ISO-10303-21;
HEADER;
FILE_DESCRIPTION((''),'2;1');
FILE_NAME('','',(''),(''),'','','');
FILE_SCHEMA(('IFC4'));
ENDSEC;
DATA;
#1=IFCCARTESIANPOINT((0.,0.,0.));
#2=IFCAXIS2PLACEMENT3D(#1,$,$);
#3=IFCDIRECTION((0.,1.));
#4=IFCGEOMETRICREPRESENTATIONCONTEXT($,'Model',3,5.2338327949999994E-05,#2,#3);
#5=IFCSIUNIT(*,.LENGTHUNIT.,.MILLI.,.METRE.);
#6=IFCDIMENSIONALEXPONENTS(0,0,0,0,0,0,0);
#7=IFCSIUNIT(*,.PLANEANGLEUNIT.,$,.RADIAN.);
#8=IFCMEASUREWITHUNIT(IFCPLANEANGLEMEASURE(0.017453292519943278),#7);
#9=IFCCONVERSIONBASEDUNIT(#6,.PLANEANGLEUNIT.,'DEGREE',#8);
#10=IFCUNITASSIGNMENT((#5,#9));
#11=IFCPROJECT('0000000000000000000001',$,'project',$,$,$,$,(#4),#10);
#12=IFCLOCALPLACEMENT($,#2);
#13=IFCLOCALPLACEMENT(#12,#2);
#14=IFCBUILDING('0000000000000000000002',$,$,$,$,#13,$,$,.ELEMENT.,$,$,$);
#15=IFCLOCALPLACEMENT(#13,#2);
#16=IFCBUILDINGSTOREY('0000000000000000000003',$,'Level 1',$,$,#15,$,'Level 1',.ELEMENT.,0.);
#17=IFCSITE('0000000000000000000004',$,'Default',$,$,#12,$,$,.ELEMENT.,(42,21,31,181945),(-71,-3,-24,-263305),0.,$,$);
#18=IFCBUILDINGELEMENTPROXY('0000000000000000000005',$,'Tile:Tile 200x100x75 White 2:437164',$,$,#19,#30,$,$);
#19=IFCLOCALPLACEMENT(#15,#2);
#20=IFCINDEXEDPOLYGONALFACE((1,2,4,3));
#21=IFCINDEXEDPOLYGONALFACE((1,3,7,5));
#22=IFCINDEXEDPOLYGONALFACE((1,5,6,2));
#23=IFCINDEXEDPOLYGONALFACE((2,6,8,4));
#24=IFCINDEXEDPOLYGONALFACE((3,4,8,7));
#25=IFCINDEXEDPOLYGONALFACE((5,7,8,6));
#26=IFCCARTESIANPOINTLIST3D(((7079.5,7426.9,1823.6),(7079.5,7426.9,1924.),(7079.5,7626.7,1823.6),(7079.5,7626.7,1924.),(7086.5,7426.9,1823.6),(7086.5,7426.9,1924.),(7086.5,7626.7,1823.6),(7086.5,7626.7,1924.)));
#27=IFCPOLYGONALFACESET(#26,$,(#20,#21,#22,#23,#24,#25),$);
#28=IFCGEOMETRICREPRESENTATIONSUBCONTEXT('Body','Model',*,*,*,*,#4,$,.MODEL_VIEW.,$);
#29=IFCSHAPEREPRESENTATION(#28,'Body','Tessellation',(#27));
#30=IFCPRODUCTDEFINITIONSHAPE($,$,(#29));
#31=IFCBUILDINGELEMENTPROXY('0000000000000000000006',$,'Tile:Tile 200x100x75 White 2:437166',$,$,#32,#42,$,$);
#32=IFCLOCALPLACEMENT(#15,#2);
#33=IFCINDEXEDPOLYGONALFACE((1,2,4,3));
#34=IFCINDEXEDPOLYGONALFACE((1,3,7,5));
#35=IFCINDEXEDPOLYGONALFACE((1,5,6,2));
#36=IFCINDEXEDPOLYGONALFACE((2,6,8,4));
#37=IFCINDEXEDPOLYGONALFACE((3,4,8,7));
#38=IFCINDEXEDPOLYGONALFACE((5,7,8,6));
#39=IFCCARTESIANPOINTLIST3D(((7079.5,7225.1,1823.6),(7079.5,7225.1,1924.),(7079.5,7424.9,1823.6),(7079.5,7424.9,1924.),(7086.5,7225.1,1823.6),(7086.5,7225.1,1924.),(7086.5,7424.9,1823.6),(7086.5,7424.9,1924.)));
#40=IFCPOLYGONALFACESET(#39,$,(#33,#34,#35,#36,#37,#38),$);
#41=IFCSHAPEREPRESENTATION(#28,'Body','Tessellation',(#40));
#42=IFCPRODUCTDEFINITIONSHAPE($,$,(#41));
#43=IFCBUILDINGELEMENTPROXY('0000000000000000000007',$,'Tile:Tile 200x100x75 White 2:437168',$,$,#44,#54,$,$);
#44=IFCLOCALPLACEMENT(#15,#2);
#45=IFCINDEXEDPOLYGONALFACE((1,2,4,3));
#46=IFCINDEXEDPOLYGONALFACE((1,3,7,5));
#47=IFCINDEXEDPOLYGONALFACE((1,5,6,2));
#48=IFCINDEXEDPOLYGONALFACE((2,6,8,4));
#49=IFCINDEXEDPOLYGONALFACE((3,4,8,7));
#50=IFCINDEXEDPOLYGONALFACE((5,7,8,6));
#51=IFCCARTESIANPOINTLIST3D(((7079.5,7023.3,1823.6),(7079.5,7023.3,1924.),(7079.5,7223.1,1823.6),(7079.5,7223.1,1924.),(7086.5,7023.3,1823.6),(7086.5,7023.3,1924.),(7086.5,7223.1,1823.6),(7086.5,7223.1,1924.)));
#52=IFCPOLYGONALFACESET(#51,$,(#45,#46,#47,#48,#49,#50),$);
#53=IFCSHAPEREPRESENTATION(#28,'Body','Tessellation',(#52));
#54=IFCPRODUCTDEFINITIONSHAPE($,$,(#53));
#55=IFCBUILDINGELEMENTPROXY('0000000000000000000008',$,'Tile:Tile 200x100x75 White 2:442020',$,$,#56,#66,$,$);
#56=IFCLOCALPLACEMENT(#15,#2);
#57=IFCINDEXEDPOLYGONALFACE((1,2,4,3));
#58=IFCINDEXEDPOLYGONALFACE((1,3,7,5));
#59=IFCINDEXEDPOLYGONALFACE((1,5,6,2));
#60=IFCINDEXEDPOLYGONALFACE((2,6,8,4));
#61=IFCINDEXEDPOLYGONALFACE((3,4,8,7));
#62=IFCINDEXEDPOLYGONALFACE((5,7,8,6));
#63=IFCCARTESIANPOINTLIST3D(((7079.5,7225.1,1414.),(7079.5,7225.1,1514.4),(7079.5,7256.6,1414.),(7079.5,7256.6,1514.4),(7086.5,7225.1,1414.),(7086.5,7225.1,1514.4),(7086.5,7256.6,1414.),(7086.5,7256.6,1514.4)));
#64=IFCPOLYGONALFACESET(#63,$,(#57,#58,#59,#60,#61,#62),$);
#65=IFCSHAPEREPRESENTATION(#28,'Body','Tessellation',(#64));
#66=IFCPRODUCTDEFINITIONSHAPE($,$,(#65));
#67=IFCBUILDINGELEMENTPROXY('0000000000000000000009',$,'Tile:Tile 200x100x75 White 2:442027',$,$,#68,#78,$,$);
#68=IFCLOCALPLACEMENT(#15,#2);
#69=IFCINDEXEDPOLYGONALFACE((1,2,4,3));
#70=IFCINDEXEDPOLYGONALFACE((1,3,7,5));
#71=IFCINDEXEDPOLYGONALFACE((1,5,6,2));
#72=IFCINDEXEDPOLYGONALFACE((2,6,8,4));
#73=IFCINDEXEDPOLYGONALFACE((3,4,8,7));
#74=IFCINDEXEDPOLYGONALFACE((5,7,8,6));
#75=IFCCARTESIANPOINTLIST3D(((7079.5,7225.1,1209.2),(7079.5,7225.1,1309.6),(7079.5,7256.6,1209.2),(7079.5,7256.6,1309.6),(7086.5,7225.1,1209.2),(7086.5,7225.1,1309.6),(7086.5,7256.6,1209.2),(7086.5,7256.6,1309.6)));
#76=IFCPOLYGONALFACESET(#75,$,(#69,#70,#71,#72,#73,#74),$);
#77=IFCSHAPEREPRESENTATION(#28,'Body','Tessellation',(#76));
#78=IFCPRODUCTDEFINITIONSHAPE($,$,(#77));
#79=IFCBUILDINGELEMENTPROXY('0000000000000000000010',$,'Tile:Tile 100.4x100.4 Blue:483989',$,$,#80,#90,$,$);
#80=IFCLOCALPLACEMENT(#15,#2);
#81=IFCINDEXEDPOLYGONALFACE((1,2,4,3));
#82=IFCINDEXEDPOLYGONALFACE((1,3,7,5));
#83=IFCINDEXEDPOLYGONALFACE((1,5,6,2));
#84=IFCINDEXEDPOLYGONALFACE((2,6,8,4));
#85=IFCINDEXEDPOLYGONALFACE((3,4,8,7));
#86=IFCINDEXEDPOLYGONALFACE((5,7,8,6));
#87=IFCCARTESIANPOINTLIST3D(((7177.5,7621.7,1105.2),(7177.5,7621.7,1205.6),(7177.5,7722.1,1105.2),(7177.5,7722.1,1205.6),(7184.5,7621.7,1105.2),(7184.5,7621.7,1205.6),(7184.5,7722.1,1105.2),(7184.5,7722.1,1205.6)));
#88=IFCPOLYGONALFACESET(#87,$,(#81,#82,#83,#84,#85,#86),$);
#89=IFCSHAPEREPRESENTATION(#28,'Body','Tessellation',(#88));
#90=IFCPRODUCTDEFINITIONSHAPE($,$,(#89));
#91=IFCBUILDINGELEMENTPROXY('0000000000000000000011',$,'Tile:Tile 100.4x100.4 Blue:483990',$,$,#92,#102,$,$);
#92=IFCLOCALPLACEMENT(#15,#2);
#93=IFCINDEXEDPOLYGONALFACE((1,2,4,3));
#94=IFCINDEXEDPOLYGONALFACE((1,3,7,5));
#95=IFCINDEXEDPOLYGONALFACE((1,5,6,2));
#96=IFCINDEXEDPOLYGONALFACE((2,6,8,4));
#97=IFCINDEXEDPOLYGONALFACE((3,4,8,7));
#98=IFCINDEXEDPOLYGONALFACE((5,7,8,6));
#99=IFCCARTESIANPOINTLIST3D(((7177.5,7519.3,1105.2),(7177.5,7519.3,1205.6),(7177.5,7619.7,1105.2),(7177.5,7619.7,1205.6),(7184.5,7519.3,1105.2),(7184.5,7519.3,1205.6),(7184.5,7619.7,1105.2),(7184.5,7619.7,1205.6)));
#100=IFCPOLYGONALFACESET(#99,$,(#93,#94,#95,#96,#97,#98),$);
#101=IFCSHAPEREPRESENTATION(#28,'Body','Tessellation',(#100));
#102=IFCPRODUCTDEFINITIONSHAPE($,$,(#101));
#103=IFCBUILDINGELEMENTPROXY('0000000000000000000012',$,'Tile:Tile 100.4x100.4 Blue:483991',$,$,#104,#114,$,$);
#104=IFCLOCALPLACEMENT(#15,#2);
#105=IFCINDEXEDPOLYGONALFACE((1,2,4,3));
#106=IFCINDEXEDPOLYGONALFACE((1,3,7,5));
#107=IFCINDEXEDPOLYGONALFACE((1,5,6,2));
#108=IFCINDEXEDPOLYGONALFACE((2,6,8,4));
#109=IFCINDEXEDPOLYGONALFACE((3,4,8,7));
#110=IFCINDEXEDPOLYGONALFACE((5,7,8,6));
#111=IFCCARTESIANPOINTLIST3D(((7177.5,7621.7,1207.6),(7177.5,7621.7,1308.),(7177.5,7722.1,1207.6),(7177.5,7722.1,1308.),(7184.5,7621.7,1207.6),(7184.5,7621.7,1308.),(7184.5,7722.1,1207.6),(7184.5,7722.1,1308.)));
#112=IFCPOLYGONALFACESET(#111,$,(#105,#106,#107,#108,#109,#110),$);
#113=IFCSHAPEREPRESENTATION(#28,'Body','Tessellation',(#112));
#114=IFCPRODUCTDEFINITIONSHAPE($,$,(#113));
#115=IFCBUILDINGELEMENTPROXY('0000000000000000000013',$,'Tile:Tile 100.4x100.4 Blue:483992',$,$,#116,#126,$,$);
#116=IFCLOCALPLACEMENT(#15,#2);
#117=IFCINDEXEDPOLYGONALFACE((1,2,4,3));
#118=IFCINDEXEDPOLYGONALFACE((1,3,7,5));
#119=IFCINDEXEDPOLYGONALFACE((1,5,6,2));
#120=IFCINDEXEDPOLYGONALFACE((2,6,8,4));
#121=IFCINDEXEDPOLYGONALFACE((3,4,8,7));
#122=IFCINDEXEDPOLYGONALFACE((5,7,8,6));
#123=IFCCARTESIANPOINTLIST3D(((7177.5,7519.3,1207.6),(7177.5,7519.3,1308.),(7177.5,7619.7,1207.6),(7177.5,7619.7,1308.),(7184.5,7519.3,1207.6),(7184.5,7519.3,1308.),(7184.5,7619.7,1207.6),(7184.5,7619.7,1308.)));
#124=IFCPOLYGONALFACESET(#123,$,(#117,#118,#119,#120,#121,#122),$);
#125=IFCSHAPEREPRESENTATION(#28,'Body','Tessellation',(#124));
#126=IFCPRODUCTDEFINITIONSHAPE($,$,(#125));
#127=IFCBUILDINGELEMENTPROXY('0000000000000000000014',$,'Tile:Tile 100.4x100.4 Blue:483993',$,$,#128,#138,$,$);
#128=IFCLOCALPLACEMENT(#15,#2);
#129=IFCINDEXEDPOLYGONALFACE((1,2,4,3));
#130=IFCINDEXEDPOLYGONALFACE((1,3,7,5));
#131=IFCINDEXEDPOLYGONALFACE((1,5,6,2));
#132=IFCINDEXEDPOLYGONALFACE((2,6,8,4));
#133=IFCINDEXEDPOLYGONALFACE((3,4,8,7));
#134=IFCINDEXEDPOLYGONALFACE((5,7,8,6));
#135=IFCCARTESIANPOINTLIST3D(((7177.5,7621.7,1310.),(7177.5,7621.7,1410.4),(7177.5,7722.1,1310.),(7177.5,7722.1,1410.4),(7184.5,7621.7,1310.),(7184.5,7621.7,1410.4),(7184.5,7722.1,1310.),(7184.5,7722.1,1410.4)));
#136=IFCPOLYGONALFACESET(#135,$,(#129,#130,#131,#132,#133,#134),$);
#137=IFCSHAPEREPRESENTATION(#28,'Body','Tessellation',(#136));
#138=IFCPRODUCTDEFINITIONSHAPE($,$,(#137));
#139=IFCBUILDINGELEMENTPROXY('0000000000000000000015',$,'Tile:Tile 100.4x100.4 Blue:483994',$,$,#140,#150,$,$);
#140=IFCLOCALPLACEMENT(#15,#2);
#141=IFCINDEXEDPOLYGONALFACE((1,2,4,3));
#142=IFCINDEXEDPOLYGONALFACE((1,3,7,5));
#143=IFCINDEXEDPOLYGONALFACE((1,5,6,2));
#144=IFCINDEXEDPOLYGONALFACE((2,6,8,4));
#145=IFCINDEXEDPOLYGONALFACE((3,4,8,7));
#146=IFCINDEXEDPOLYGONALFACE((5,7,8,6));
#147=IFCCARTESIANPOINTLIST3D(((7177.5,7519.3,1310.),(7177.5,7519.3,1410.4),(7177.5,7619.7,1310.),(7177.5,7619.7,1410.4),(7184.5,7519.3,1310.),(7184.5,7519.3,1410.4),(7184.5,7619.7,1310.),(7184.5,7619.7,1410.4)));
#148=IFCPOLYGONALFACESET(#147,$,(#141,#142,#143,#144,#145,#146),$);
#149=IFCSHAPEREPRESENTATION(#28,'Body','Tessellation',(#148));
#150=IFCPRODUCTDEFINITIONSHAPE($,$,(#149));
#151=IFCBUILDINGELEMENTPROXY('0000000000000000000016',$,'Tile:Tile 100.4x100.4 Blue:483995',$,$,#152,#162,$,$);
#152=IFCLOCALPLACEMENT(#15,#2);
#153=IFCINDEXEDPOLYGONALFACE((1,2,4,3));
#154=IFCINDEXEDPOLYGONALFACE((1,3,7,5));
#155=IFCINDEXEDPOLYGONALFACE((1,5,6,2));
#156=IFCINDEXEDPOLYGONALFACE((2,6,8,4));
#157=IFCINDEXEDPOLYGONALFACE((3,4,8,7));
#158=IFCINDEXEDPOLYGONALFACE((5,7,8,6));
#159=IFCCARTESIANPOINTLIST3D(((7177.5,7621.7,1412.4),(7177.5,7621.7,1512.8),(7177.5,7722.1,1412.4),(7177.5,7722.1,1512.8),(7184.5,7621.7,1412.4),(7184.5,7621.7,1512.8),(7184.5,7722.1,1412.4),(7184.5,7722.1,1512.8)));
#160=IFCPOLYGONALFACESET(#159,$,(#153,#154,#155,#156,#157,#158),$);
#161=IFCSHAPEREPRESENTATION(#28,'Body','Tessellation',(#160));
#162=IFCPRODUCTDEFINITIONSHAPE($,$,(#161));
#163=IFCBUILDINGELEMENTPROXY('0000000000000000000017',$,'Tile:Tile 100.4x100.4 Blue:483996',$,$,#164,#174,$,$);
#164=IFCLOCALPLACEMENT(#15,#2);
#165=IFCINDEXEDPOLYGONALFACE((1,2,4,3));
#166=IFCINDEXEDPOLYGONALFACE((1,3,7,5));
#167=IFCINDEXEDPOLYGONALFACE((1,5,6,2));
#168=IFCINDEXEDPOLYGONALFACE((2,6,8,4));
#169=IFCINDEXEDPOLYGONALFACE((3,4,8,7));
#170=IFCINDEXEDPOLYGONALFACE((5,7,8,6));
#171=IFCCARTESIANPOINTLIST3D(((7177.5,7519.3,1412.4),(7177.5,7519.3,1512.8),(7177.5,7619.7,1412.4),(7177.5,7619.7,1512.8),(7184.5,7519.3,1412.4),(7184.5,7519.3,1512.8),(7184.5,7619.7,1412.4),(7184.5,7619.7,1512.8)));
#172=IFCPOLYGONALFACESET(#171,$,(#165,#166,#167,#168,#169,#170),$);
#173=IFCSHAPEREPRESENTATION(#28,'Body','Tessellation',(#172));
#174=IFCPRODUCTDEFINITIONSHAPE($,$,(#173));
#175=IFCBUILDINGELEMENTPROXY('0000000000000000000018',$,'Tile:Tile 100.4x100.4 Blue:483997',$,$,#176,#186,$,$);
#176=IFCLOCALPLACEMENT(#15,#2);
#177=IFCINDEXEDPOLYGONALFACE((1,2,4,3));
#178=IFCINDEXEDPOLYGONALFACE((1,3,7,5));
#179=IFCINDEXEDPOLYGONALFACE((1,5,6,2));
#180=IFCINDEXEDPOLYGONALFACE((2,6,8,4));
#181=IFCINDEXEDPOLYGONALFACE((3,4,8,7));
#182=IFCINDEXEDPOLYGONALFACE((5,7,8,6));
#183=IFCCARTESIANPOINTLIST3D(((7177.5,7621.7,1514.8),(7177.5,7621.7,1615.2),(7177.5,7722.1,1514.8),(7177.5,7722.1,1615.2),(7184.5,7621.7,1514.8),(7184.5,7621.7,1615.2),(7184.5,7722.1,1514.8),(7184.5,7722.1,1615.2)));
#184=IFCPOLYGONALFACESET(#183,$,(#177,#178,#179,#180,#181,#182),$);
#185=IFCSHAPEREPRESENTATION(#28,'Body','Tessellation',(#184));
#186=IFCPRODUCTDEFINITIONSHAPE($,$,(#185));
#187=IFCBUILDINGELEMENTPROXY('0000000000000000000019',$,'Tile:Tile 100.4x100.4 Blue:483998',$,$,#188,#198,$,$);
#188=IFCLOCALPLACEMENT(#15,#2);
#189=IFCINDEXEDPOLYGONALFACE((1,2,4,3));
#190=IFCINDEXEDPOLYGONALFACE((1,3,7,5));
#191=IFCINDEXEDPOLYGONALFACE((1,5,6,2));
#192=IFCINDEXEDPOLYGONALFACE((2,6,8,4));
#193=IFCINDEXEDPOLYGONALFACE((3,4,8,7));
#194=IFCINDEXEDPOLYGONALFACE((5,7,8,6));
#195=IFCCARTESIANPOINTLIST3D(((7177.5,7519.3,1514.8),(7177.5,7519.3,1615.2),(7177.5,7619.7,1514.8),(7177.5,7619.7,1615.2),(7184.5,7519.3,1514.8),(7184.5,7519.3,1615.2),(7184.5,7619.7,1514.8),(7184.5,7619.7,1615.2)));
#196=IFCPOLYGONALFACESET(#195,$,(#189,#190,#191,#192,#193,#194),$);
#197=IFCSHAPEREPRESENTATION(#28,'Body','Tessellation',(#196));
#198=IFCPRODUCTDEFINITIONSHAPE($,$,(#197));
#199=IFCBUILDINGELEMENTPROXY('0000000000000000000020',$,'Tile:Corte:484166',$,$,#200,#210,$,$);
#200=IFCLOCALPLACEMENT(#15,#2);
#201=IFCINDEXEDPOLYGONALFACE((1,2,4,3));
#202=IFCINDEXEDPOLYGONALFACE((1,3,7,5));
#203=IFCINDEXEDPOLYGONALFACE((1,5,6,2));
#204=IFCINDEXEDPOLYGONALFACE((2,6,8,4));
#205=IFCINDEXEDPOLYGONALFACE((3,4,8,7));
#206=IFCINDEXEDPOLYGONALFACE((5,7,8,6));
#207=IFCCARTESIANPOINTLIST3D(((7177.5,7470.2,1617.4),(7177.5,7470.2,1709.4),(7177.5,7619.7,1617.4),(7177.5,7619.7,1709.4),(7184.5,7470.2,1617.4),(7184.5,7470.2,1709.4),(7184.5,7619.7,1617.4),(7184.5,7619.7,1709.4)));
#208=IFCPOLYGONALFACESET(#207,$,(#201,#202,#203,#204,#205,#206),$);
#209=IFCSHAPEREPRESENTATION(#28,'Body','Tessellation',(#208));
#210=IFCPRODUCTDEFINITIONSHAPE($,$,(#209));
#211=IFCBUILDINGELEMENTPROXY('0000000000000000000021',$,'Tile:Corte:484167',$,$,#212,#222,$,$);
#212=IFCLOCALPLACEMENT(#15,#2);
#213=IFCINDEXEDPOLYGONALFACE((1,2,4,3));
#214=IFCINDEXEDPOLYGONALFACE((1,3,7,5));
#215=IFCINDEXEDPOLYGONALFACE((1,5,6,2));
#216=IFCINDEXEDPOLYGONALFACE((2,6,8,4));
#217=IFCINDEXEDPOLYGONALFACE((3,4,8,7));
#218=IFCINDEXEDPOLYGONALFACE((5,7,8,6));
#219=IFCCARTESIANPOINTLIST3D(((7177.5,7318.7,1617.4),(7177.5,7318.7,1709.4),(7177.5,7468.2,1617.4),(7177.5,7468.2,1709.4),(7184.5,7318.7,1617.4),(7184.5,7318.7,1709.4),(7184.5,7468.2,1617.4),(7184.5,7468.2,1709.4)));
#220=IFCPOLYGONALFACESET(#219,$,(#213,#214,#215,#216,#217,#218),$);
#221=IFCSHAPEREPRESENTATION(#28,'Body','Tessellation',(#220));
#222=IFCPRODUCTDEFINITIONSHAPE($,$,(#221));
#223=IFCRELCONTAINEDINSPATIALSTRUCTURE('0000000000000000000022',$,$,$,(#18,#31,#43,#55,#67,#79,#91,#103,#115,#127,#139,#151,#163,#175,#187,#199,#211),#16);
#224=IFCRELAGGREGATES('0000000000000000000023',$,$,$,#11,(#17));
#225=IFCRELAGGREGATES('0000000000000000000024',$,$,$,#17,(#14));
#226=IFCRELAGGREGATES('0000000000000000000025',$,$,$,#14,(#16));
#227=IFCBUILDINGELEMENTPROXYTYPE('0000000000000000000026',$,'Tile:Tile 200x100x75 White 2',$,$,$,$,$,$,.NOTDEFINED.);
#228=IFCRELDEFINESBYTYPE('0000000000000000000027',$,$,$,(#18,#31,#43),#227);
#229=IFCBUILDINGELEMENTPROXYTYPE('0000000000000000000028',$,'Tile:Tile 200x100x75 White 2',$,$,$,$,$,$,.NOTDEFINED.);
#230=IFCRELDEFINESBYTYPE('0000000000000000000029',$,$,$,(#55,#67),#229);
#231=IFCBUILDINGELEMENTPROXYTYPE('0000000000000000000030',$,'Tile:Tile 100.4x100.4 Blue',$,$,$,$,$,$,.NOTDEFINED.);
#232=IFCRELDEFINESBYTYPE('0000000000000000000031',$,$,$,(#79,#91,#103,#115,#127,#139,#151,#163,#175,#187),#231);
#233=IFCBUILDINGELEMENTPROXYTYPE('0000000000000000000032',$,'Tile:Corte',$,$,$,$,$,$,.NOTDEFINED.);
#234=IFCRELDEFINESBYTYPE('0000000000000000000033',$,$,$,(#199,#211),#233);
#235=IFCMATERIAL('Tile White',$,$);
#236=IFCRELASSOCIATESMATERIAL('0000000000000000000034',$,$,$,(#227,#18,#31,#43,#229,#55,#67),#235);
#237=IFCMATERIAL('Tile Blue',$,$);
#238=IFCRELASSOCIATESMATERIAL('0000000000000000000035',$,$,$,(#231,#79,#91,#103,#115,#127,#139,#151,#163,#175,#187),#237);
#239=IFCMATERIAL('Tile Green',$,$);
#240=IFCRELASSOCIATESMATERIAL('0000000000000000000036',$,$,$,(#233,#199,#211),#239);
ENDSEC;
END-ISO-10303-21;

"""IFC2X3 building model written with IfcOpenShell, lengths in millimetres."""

from ifc_helpers import new_model, entity, si_unit, converted_unit, direction, frame, frame_2d, origin, origin_2d_with_axis, place, context, subcontext, project, spatial, rectangle, extrude, source, transform, mapped, material, type_object, type_shapes, element, save


model = new_model("IFC2X3")

# Units and contexts
model_context = context("Model", 3, precision=5.2338327949999994e-05, world=origin(), true_north=direction((0.0, 1.0)))
body_context = subcontext(model_context, "Body", "Model", "MODEL_VIEW")
ifc_project = project(units=[si_unit("LENGTHUNIT", "METRE", prefix="MILLI"), converted_unit("PLANEANGLEUNIT", "DEGREE", entity("IfcPlaneAngleMeasure", 0.017453292519943278), si_unit("PLANEANGLEUNIT", "RADIAN"), dimensions=[0, 0, 0, 0, 0, 0, 0])], contexts=[model_context])

# Site, building, storey
site_placement = place(None, origin())
site = spatial("IfcSite", under=ifc_project, at=site_placement, Name="Default", CompositionType="ELEMENT", RefLatitude=(42, 21, 31, 181945), RefLongitude=(-71, -3, -24, -263305), RefElevation=0.0)
building_placement = place(site_placement, origin())
building = spatial("IfcBuilding", under=site, at=building_placement, CompositionType="ELEMENT")
storey_placement = place(building_placement, origin())
storey = spatial("IfcBuildingStorey", under=building, at=storey_placement, Name="Level 1", LongName="Level 1", CompositionType="ELEMENT", Elevation=0.0)

# Building element proxies
ifc_material_1 = material(Name="Tile White")
building_element_proxy_type_1 = type_object("IfcBuildingElementProxyType", Name="Tile:Tile 200x100x75 White 2", PredefinedType="NOTDEFINED", material=ifc_material_1)
shared_shape_1 = source(origin(), body_context, "Body", "SweptSolid", [
    extrude(rectangle(XDim=199.8, YDim=100.4, at=frame_2d((0.0, 0.0), x_axis=(1.0, 0.0))), frame((-50.2, -99.9, 0.0), z_axis=(0.0, 0.0, 1.0), x_axis=(0.0, -1.0, 0.0)), (0.0, 0.0, 1.0), 7.0),
])
type_shapes(building_element_proxy_type_1, [shared_shape_1])
for number, where, z_axis, x_axis, name in (
    (1, (7086.5, 7626.7, 1924.0), (-1.0, 0.0, 0.0), (0.0, 0.0, 1.0), "Tile:Tile 200x100x75 White 2:437164"),
    (2, (7086.5, 7424.9, 1924.0), (-1.0, 0.0, 0.0), (0.0, 0.0, 1.0), "Tile:Tile 200x100x75 White 2:437166"),
    (3, (7086.5, 7223.1, 1924.0), (-1.0, 0.0, 0.0), (0.0, 0.0, 1.0), "Tile:Tile 200x100x75 White 2:437168"),
):
    element("IfcBuildingElementProxy", number, at=place(storey_placement, frame(where, z_axis=z_axis, x_axis=x_axis)), inside=storey, type_object=building_element_proxy_type_1, material=ifc_material_1, Name=name, context=body_context, shape_type="MappedRepresentation", body=[
        mapped(shared_shape_1, transform((0.0, 0.0, 0.0), scale=1.0)),
    ])
building_element_proxy_type_2 = type_object("IfcBuildingElementProxyType", Name="Tile:Tile 200x100x75 White 2", PredefinedType="NOTDEFINED", material=ifc_material_1)
shared_shape_2 = source(origin(), body_context, "Body", "SweptSolid", [
    extrude(rectangle(XDim=100.4, YDim=31.5, at=origin_2d_with_axis()), frame((-50.2, 15.8, 0.0)), (0.0, 0.0, 1.0), 7.0),
])
type_shapes(building_element_proxy_type_2, [shared_shape_2])
for number, where, z_axis, x_axis, name in (
    (4, (7086.5, 7225.1, 1514.4), (-1.0, 0.0, 0.0), (0.0, 0.0, 1.0), "Tile:Tile 200x100x75 White 2:442020"),
    (5, (7086.5, 7225.1, 1309.6), (-1.0, 0.0, 0.0), (0.0, 0.0, 1.0), "Tile:Tile 200x100x75 White 2:442027"),
):
    element("IfcBuildingElementProxy", number, at=place(storey_placement, frame(where, z_axis=z_axis, x_axis=x_axis)), inside=storey, type_object=building_element_proxy_type_2, material=ifc_material_1, Name=name, context=body_context, shape_type="MappedRepresentation", body=[
        mapped(shared_shape_2, transform((0.0, 0.0, 0.0), scale=1.0)),
    ])
ifc_material_2 = material(Name="Tile Blue")
building_element_proxy_type_3 = type_object("IfcBuildingElementProxyType", Name="Tile:Tile 100.4x100.4 Blue", PredefinedType="NOTDEFINED", material=ifc_material_2)
shared_shape_3 = source(origin(), body_context, "Body", "SweptSolid", [
    extrude(rectangle(XDim=100.4, YDim=100.4, at=origin_2d_with_axis()), frame((-50.2, -50.2, 0.0), z_axis=(0.0, 0.0, 1.0), x_axis=(0.0, -1.0, 0.0)), (0.0, 0.0, 1.0), 7.0),
])
type_shapes(building_element_proxy_type_3, [shared_shape_3])
for number, where, z_axis, x_axis, name in (
    (6, (7184.5, 7722.1, 1105.2), (-1.0, 0.0, 0.0), (0.0, 1.0, 0.0), "Tile:Tile 100.4x100.4 Blue:483989"),
    (7, (7184.5, 7619.7, 1105.2), (-1.0, 0.0, 0.0), (0.0, 1.0, 0.0), "Tile:Tile 100.4x100.4 Blue:483990"),
    (8, (7184.5, 7722.1, 1207.6), (-1.0, 0.0, 0.0), (0.0, 1.0, 0.0), "Tile:Tile 100.4x100.4 Blue:483991"),
    (9, (7184.5, 7619.7, 1207.6), (-1.0, 0.0, 0.0), (0.0, 1.0, 0.0), "Tile:Tile 100.4x100.4 Blue:483992"),
    (10, (7184.5, 7722.1, 1310.0), (-1.0, 0.0, 0.0), (0.0, 1.0, 0.0), "Tile:Tile 100.4x100.4 Blue:483993"),
    (11, (7184.5, 7619.7, 1310.0), (-1.0, 0.0, 0.0), (0.0, 1.0, 0.0), "Tile:Tile 100.4x100.4 Blue:483994"),
    (12, (7184.5, 7722.1, 1412.4), (-1.0, 0.0, 0.0), (0.0, 1.0, 0.0), "Tile:Tile 100.4x100.4 Blue:483995"),
    (13, (7184.5, 7619.7, 1412.4), (-1.0, 0.0, 0.0), (0.0, 1.0, 0.0), "Tile:Tile 100.4x100.4 Blue:483996"),
    (14, (7184.5, 7722.1, 1514.8), (-1.0, 0.0, 0.0), (0.0, 1.0, 0.0), "Tile:Tile 100.4x100.4 Blue:483997"),
    (15, (7184.5, 7619.7, 1514.8), (-1.0, 0.0, 0.0), (0.0, 1.0, 0.0), "Tile:Tile 100.4x100.4 Blue:483998"),
):
    element("IfcBuildingElementProxy", number, at=place(storey_placement, frame(where, z_axis=z_axis, x_axis=x_axis)), inside=storey, type_object=building_element_proxy_type_3, material=ifc_material_2, Name=name, context=body_context, shape_type="MappedRepresentation", body=[
        mapped(shared_shape_3, transform((0.0, 0.0, 0.0), scale=1.0)),
    ])
ifc_material_3 = material(Name="Tile Green")
building_element_proxy_type_4 = type_object("IfcBuildingElementProxyType", Name="Tile:Corte", PredefinedType="NOTDEFINED", material=ifc_material_3)
shared_shape_4 = source(origin(), body_context, "Body", "SweptSolid", [
    extrude(rectangle(XDim=149.5, YDim=92.0, at=origin_2d_with_axis()), frame((-46.0, -74.8, 0.0), z_axis=(0.0, 0.0, 1.0), x_axis=(0.0, -1.0, 0.0)), (0.0, 0.0, 1.0), 7.0),
])
type_shapes(building_element_proxy_type_4, [shared_shape_4])
for number, where, z_axis, x_axis, name in (
    (16, (7184.5, 7619.7, 1709.4), (-1.0, 0.0, 0.0), (0.0, 0.0, 1.0), "Tile:Corte:484166"),
    (17, (7184.5, 7468.2, 1709.4), (-1.0, 0.0, 0.0), (0.0, 0.0, 1.0), "Tile:Corte:484167"),
):
    element("IfcBuildingElementProxy", number, at=place(storey_placement, frame(where, z_axis=z_axis, x_axis=x_axis)), inside=storey, type_object=building_element_proxy_type_4, material=ifc_material_3, Name=name, context=body_context, shape_type="MappedRepresentation", body=[
        mapped(shared_shape_4, transform((0.0, 0.0, 0.0), scale=1.0)),
    ])

save(model, "model.ifc")
